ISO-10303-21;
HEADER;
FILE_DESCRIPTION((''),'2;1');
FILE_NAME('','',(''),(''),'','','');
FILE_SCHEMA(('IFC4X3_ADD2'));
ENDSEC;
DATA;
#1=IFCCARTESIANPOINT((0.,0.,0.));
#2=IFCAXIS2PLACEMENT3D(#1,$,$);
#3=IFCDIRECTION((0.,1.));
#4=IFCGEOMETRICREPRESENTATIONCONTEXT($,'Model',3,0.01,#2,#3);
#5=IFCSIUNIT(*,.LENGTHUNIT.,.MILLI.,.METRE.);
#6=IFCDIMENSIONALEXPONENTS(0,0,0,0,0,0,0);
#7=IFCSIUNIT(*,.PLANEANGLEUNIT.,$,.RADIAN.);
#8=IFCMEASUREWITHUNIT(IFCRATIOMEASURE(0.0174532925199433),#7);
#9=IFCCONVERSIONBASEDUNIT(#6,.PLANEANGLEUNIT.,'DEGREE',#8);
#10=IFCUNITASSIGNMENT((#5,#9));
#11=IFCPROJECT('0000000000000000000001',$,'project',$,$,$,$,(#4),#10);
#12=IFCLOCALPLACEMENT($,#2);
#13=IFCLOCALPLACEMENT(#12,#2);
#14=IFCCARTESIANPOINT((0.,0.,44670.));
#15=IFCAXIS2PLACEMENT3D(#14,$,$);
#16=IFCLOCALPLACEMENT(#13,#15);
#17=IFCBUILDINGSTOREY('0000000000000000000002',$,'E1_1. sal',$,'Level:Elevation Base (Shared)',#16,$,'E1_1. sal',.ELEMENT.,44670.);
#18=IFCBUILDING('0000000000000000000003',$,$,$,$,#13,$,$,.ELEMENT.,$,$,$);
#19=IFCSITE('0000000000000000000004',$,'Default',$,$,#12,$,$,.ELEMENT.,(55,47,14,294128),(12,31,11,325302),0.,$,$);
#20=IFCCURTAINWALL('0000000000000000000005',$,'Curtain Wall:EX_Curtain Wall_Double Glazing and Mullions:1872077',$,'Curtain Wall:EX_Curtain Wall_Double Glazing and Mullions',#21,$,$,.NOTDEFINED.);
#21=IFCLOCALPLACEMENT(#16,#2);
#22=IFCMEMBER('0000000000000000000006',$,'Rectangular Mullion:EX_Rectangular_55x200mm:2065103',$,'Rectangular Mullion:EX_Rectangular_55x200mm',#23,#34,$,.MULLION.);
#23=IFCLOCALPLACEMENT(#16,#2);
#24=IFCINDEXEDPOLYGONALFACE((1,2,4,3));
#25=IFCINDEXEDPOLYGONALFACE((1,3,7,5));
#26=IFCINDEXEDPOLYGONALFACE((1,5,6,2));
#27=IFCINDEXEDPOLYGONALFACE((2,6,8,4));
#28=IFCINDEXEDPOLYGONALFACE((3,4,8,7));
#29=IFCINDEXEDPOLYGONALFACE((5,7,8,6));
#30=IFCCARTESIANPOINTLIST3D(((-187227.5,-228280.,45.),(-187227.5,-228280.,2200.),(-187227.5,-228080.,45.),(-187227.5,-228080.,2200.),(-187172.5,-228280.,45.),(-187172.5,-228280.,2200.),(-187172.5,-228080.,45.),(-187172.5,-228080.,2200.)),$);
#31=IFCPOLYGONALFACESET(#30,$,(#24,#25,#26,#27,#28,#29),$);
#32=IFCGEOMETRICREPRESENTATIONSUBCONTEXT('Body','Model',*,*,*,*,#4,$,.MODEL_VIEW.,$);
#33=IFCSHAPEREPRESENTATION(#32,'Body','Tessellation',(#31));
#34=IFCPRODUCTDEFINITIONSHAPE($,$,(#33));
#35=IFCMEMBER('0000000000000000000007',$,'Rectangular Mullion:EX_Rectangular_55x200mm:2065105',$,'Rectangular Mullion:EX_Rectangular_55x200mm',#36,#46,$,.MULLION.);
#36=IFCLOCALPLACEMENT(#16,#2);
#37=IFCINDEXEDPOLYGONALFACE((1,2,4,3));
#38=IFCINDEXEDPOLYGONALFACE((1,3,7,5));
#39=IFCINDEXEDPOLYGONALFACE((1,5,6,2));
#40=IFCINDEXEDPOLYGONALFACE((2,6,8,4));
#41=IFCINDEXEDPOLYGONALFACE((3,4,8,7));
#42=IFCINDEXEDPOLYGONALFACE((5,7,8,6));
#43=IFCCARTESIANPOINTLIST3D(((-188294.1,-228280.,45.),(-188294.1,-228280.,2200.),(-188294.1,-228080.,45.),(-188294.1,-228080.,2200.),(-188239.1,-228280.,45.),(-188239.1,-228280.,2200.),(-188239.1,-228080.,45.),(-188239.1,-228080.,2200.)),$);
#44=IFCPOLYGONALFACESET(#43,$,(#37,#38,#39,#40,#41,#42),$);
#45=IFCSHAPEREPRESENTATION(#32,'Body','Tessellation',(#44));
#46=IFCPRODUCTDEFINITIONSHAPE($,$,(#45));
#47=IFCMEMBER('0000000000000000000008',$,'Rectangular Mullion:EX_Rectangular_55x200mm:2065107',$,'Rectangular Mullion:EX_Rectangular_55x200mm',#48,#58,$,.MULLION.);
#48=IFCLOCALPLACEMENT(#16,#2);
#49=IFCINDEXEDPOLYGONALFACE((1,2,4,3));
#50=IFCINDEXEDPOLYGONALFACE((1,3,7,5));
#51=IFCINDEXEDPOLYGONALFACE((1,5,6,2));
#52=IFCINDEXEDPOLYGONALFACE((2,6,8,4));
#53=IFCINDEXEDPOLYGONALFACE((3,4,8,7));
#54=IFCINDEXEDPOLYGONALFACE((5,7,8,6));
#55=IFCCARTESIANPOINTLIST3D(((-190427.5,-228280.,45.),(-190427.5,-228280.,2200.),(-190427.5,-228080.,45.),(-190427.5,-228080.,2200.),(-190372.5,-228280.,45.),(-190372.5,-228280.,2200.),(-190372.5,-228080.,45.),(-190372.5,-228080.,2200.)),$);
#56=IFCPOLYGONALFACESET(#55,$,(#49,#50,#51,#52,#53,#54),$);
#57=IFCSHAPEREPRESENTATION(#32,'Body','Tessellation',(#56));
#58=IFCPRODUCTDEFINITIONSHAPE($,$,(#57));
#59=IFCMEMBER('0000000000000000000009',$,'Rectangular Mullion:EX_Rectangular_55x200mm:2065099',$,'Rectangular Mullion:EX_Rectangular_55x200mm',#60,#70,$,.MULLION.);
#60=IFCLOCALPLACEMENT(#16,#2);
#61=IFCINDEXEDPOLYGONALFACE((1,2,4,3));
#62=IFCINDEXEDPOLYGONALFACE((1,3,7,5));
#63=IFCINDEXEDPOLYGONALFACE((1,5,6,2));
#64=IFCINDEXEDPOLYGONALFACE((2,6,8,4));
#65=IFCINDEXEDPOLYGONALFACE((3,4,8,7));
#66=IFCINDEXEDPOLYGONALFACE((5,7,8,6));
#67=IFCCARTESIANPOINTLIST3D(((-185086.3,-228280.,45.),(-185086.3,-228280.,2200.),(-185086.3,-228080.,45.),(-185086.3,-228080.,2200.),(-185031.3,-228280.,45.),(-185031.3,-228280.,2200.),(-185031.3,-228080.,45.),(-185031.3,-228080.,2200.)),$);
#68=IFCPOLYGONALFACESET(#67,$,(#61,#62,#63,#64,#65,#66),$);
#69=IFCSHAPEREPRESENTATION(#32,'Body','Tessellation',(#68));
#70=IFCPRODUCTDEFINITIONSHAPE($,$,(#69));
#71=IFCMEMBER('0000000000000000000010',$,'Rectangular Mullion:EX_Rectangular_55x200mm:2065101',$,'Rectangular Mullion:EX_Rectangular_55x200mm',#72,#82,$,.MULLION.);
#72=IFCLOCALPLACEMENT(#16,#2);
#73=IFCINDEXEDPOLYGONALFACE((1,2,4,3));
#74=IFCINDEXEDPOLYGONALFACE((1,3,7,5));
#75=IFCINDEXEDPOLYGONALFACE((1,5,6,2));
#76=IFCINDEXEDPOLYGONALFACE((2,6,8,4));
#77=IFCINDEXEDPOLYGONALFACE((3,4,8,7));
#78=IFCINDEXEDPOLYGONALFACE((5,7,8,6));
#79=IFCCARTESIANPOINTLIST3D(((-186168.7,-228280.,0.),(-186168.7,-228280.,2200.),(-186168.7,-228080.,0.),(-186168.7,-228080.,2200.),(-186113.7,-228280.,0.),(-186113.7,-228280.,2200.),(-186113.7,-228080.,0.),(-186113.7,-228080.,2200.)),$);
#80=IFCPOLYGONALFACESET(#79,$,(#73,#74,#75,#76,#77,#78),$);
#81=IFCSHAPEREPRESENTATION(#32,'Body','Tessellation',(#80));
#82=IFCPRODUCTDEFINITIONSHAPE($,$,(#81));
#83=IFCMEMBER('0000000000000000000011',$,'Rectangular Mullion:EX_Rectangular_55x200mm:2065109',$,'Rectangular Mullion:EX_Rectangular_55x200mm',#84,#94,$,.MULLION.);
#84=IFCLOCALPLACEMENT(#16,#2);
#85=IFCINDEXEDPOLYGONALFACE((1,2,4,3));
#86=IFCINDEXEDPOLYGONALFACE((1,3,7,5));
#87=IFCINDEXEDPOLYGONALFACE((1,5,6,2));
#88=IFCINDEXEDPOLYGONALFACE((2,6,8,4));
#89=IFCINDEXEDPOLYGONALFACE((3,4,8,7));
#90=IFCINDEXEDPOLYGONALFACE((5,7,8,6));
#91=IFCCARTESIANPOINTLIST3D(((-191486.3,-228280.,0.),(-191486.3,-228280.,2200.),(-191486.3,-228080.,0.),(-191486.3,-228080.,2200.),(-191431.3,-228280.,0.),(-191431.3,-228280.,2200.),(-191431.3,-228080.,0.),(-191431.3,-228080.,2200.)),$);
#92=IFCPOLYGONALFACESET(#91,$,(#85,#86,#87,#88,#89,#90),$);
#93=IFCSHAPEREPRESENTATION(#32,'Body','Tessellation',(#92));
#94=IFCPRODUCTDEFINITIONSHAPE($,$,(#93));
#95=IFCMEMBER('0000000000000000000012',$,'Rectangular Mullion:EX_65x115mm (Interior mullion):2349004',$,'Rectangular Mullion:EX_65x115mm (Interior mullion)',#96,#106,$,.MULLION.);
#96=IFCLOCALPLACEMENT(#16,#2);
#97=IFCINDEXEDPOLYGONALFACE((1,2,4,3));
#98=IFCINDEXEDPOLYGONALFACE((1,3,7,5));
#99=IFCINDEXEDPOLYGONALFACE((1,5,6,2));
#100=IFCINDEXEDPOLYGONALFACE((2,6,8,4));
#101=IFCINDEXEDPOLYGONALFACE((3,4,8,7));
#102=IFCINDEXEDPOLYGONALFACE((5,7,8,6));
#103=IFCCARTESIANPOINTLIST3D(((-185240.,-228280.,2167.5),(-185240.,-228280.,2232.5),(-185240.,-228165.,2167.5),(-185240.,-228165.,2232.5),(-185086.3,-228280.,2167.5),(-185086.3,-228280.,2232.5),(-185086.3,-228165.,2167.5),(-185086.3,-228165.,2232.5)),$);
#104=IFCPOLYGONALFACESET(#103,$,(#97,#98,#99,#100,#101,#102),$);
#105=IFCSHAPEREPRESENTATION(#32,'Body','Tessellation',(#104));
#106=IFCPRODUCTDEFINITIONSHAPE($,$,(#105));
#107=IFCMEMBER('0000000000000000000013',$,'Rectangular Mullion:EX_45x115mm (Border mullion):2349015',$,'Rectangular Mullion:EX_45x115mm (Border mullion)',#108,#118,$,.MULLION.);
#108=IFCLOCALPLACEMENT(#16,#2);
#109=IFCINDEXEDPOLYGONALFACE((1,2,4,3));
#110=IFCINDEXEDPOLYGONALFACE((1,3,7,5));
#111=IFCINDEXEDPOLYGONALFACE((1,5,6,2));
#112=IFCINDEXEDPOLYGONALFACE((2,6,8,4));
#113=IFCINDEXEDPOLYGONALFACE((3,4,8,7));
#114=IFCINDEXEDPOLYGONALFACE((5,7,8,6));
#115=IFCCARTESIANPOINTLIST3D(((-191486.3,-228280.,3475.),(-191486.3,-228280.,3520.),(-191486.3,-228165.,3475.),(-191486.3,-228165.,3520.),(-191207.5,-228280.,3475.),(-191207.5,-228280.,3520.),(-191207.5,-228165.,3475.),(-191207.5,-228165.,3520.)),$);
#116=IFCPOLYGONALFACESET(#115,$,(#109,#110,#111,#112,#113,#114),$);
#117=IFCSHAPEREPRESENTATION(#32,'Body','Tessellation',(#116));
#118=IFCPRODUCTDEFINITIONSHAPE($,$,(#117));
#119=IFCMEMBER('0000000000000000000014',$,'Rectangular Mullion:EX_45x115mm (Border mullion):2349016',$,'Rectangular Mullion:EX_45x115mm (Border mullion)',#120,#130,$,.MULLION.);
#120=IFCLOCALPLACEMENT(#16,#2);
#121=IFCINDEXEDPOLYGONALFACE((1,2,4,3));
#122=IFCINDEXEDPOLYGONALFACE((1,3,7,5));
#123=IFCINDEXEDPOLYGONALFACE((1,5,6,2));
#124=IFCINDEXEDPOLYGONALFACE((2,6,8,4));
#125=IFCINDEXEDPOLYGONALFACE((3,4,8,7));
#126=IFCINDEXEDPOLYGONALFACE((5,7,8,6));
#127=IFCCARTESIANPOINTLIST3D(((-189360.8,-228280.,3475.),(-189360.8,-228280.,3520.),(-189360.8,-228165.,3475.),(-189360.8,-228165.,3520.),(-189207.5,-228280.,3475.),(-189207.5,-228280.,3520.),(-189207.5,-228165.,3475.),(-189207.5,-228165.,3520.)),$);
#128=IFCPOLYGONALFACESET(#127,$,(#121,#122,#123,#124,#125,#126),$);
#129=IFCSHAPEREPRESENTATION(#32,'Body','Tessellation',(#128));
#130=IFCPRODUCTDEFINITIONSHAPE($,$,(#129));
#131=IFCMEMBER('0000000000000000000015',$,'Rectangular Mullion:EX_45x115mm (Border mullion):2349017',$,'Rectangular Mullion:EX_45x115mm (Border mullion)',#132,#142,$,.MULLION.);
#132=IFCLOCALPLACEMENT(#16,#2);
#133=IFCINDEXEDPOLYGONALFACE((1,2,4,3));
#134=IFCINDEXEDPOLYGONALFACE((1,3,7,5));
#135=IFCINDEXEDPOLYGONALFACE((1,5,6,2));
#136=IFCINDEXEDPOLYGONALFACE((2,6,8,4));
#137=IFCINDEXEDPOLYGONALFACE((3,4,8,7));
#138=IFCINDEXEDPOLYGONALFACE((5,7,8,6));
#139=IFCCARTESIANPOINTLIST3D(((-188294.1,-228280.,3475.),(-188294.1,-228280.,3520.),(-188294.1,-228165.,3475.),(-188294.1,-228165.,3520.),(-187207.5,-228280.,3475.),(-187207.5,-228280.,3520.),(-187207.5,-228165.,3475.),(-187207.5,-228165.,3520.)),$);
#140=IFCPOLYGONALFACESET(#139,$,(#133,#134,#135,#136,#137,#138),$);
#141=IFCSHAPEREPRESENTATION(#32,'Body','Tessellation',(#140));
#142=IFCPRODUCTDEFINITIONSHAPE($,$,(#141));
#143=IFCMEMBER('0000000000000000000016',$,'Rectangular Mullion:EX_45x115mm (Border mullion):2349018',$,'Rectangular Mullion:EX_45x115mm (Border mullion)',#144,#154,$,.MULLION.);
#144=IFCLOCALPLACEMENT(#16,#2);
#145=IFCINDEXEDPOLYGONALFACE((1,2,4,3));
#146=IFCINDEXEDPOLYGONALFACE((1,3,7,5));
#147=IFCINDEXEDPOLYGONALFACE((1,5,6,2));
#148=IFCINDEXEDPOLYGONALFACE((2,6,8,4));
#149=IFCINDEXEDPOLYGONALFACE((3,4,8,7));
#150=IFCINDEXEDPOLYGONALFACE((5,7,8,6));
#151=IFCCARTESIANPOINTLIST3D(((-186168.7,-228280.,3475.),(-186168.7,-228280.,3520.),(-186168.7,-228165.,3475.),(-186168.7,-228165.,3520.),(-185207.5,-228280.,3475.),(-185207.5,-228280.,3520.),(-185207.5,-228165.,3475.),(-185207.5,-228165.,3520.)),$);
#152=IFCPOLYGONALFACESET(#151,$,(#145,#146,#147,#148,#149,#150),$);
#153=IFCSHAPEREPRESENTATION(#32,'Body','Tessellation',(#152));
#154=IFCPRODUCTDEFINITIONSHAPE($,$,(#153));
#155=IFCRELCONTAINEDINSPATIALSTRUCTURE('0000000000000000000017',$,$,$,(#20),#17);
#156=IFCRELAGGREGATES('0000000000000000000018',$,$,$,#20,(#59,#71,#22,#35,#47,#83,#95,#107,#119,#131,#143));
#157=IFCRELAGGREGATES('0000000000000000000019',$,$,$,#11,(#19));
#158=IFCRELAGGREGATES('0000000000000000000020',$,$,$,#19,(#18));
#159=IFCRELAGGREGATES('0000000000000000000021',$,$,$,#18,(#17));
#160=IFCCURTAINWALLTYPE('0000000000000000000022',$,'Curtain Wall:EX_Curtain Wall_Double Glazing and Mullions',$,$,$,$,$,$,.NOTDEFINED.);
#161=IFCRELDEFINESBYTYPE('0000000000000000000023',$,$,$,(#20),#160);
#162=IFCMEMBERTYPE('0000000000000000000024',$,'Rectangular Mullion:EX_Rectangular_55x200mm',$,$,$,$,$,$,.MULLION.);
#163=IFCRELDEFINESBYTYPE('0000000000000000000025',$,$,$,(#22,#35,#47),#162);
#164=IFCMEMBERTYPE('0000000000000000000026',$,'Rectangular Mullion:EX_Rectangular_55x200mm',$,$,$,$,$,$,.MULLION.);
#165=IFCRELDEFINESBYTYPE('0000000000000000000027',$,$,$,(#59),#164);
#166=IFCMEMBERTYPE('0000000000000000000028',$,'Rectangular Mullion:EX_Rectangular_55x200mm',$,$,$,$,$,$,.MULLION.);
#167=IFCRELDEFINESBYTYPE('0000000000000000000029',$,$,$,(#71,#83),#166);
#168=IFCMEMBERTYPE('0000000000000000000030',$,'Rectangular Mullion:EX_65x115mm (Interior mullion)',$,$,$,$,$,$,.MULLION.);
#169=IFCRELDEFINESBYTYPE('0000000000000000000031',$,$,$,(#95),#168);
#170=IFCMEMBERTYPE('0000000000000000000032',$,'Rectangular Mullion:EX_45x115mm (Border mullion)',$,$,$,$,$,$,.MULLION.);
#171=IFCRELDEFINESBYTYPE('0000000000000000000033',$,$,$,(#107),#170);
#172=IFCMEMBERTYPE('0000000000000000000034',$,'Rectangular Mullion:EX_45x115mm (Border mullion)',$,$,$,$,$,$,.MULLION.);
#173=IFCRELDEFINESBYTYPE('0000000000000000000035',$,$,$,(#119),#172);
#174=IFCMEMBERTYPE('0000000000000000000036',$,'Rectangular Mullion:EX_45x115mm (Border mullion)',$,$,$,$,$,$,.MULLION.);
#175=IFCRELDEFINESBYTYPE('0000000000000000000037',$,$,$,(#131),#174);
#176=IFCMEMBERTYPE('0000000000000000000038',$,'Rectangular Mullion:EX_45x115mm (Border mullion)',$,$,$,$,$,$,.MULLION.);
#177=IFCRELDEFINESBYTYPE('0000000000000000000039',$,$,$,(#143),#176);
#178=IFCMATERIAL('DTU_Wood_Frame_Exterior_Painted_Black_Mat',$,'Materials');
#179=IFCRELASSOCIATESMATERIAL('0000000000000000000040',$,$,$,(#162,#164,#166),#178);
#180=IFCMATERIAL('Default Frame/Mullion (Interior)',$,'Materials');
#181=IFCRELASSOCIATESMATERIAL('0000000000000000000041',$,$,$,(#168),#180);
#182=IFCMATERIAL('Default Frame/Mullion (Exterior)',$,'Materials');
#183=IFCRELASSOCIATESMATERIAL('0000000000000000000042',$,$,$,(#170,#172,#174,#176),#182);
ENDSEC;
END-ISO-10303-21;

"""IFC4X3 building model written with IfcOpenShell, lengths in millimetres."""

from ifc_helpers import new_model, entity, si_unit, converted_unit, direction, frame, origin, origin_2d_with_axis, place, context, subcontext, project, spatial, rectangle, extrude, source, transform, mapped, material, material_profile, profile_set, type_object, type_shapes, element, aggregate, save


model = new_model("IFC4X3")

# Units and contexts
model_context = context("Model", 3, precision=0.01, world=origin(), true_north=direction((0.0, 1.0)))
body_context = subcontext(model_context, "Body", "Model", "MODEL_VIEW")
ifc_project = project(units=[si_unit("LENGTHUNIT", "METRE", prefix="MILLI"), converted_unit("PLANEANGLEUNIT", "DEGREE", entity("IfcRatioMeasure", 0.0174532925199433), si_unit("PLANEANGLEUNIT", "RADIAN"), dimensions=[0, 0, 0, 0, 0, 0, 0])], contexts=[model_context])

# Site, building, storey
site_placement = place(None, origin())
site = spatial("IfcSite", under=ifc_project, at=site_placement, Name="Default", CompositionType="ELEMENT", RefLatitude=(55, 47, 14, 294128), RefLongitude=(12, 31, 11, 325302), RefElevation=0.0)
building_placement = place(site_placement, origin())
building = spatial("IfcBuilding", under=site, at=building_placement, CompositionType="ELEMENT")
storey_placement = place(building_placement, frame((0.0, 0.0, 44670.0)))
storey = spatial("IfcBuildingStorey", under=building, at=storey_placement, Name="E1_1. sal", ObjectType="Level:Elevation Base (Shared)", LongName="E1_1. sal", CompositionType="ELEMENT", Elevation=44670.0)

# Curtain wall, members
curtain_wall_type = type_object("IfcCurtainWallType", Name="Curtain Wall:EX_Curtain Wall_Double Glazing and Mullions", PredefinedType="NOTDEFINED")
curtain_wall_placement = place(storey_placement, frame((0.0, 0.0, -44670.0)))
curtain_wall = element("IfcCurtainWall", 1, at=curtain_wall_placement, inside=storey, type_object=curtain_wall_type, Name="Curtain Wall:EX_Curtain Wall_Double Glazing and Mullions:1872077", ObjectType="Curtain Wall:EX_Curtain Wall_Double Glazing and Mullions", PredefinedType="NOTDEFINED")
ifc_material_1 = material(Name="DTU_Wood_Frame_Exterior_Painted_Black_Mat", Category="Materials")
ifc_material_profile_1 = material_profile(ifc_material_1, rectangle(XDim=200.0, YDim=55.0, at=origin_2d_with_axis()), Name="EX_Rectangular_55x200mm")
ifc_profile_set_1 = profile_set([ifc_material_profile_1], Name="EX_Rectangular_55x200mm")
member_type_1 = type_object("IfcMemberType", Name="Rectangular Mullion:EX_Rectangular_55x200mm", PredefinedType="MULLION", material=ifc_profile_set_1)
shared_shape_1 = source(origin(), body_context, "Body", "SweptSolid", [
    extrude(rectangle(XDim=200.0, YDim=55.0, at=origin_2d_with_axis()), frame((0.0, -100.0, -2155.0), z_axis=(0.0, 0.0, 1.0), x_axis=(0.0, -1.0, 0.0)), (0.0, 0.0, 1.0), 2155.0),
])
type_shapes(member_type_1, [shared_shape_1])
member_1_placement = place(curtain_wall_placement, frame((-187200.0, -228280.0, 44715.0), z_axis=(0.0, 0.0, -1.0), x_axis=(1.0, 0.0, 0.0)))
member_1 = element("IfcMember", 2, at=member_1_placement, type_object=member_type_1, Name="Rectangular Mullion:EX_Rectangular_55x200mm:2065103", ObjectType="Rectangular Mullion:EX_Rectangular_55x200mm", PredefinedType="MULLION", context=body_context, shape_type="MappedRepresentation", body=[
    mapped(shared_shape_1, transform((0.0, 0.0, 0.0), scale=1.0)),
])
member_2_placement = place(curtain_wall_placement, frame((-188266.6, -228280.0, 44715.0), z_axis=(0.0, 0.0, -1.0), x_axis=(1.0, 0.0, 0.0)))
member_2 = element("IfcMember", 3, at=member_2_placement, type_object=member_type_1, Name="Rectangular Mullion:EX_Rectangular_55x200mm:2065105", ObjectType="Rectangular Mullion:EX_Rectangular_55x200mm", PredefinedType="MULLION", context=body_context, shape_type="MappedRepresentation", body=[
    mapped(shared_shape_1, transform((0.0, 0.0, 0.0), scale=1.0)),
])
member_3_placement = place(curtain_wall_placement, frame((-190400.0, -228280.0, 44715.0), z_axis=(0.0, 0.0, -1.0), x_axis=(1.0, 0.0, 0.0)))
member_3 = element("IfcMember", 4, at=member_3_placement, type_object=member_type_1, Name="Rectangular Mullion:EX_Rectangular_55x200mm:2065107", ObjectType="Rectangular Mullion:EX_Rectangular_55x200mm", PredefinedType="MULLION", context=body_context, shape_type="MappedRepresentation", body=[
    mapped(shared_shape_1, transform((0.0, 0.0, 0.0), scale=1.0)),
])
member_type_2 = type_object("IfcMemberType", Name="Rectangular Mullion:EX_Rectangular_55x200mm", PredefinedType="MULLION", material=ifc_profile_set_1)
shared_shape_2 = source(origin(), body_context, "Body", "SweptSolid", [
    extrude(rectangle(XDim=200.0, YDim=55.0, at=origin_2d_with_axis()), frame((0.0, -100.0, -2155.0), z_axis=(0.0, 0.0, 1.0), x_axis=(0.0, -1.0, 0.0)), (0.0, 0.0, 1.0), 2155.0),
])
type_shapes(member_type_2, [shared_shape_2])
member_4_placement = place(curtain_wall_placement, frame((-185058.8, -228280.0, 44715.0), z_axis=(0.0, 0.0, -1.0), x_axis=(1.0, 0.0, 0.0)))
member_4 = element("IfcMember", 5, at=member_4_placement, type_object=member_type_2, Name="Rectangular Mullion:EX_Rectangular_55x200mm:2065099", ObjectType="Rectangular Mullion:EX_Rectangular_55x200mm", PredefinedType="MULLION", context=body_context, shape_type="MappedRepresentation", body=[
    mapped(shared_shape_2, transform((0.0, 0.0, 0.0), scale=1.0)),
])
member_type_3 = type_object("IfcMemberType", Name="Rectangular Mullion:EX_Rectangular_55x200mm", PredefinedType="MULLION", material=ifc_profile_set_1)
shared_shape_3 = source(origin(), body_context, "Body", "SweptSolid", [
    extrude(rectangle(XDim=200.0, YDim=55.0, at=origin_2d_with_axis()), frame((0.0, -100.0, -2200.0), z_axis=(0.0, 0.0, 1.0), x_axis=(0.0, -1.0, 0.0)), (0.0, 0.0, 1.0), 2200.0),
])
type_shapes(member_type_3, [shared_shape_3])
member_5_placement = place(curtain_wall_placement, frame((-186141.2, -228280.0, 44670.0), z_axis=(0.0, 0.0, -1.0), x_axis=(1.0, 0.0, 0.0)))
member_5 = element("IfcMember", 6, at=member_5_placement, type_object=member_type_3, Name="Rectangular Mullion:EX_Rectangular_55x200mm:2065101", ObjectType="Rectangular Mullion:EX_Rectangular_55x200mm", PredefinedType="MULLION", context=body_context, shape_type="MappedRepresentation", body=[
    mapped(shared_shape_3, transform((0.0, 0.0, 0.0), scale=1.0)),
])
member_6_placement = place(curtain_wall_placement, frame((-191458.8, -228280.0, 44670.0), z_axis=(0.0, 0.0, -1.0), x_axis=(1.0, 0.0, 0.0)))
member_6 = element("IfcMember", 7, at=member_6_placement, type_object=member_type_3, Name="Rectangular Mullion:EX_Rectangular_55x200mm:2065109", ObjectType="Rectangular Mullion:EX_Rectangular_55x200mm", PredefinedType="MULLION", context=body_context, shape_type="MappedRepresentation", body=[
    mapped(shared_shape_3, transform((0.0, 0.0, 0.0), scale=1.0)),
])
ifc_material_2 = material(Name="Default Frame/Mullion (Interior)", Category="Materials")
ifc_material_profile_2 = material_profile(ifc_material_2, rectangle(XDim=115.0, YDim=65.0, at=origin_2d_with_axis()), Name="EX_65x115mm (Interior mullion)")
ifc_profile_set_2 = profile_set([ifc_material_profile_2], Name="EX_65x115mm (Interior mullion)")
member_type_4 = type_object("IfcMemberType", Name="Rectangular Mullion:EX_65x115mm (Interior mullion)", PredefinedType="MULLION", material=ifc_profile_set_2)
shared_shape_4 = source(origin(), body_context, "Body", "SweptSolid", [
    extrude(rectangle(XDim=115.0, YDim=65.0, at=origin_2d_with_axis()), frame((0.0, -57.5, -153.7), z_axis=(0.0, 0.0, 1.0), x_axis=(0.0, -1.0, 0.0)), (0.0, 0.0, 1.0), 153.7),
])
type_shapes(member_type_4, [shared_shape_4])
member_7_placement = place(curtain_wall_placement, frame((-185086.3, -228280.0, 46870.0), z_axis=(1.0, 0.0, 0.0), x_axis=(0.0, 0.0, 1.0)))
member_7 = element("IfcMember", 8, at=member_7_placement, type_object=member_type_4, Name="Rectangular Mullion:EX_65x115mm (Interior mullion):2349004", ObjectType="Rectangular Mullion:EX_65x115mm (Interior mullion)", PredefinedType="MULLION", context=body_context, shape_type="MappedRepresentation", body=[
    mapped(shared_shape_4, transform((0.0, 0.0, 0.0), scale=1.0)),
])
ifc_material_3 = material(Name="Default Frame/Mullion (Exterior)", Category="Materials")
ifc_material_profile_3 = material_profile(ifc_material_3, rectangle(XDim=115.0, YDim=45.0, at=origin_2d_with_axis()), Name="EX_45x115mm (Border mullion)")
ifc_profile_set_3 = profile_set([ifc_material_profile_3], Name="EX_45x115mm (Border mullion)")
member_type_5 = type_object("IfcMemberType", Name="Rectangular Mullion:EX_45x115mm (Border mullion)", PredefinedType="MULLION", material=ifc_profile_set_3)
shared_shape_5 = source(origin(), body_context, "Body", "SweptSolid", [
    extrude(rectangle(XDim=115.0, YDim=45.0, at=origin_2d_with_axis()), frame((-22.5, -57.5, -278.8), z_axis=(0.0, 0.0, 1.0), x_axis=(0.0, -1.0, 0.0)), (0.0, 0.0, 1.0), 278.8),
])
type_shapes(member_type_5, [shared_shape_5])
member_8_placement = place(curtain_wall_placement, frame((-191207.5, -228280.0, 48190.0), z_axis=(1.0, 0.0, 0.0), x_axis=(0.0, 0.0, 1.0)))
member_8 = element("IfcMember", 9, at=member_8_placement, type_object=member_type_5, Name="Rectangular Mullion:EX_45x115mm (Border mullion):2349015", ObjectType="Rectangular Mullion:EX_45x115mm (Border mullion)", PredefinedType="MULLION", context=body_context, shape_type="MappedRepresentation", body=[
    mapped(shared_shape_5, transform((0.0, 0.0, 0.0), scale=1.0)),
])
member_type_6 = type_object("IfcMemberType", Name="Rectangular Mullion:EX_45x115mm (Border mullion)", PredefinedType="MULLION", material=ifc_profile_set_3)
shared_shape_6 = source(origin(), body_context, "Body", "SweptSolid", [
    extrude(rectangle(XDim=115.0, YDim=45.0, at=origin_2d_with_axis()), frame((-22.5, -57.5, -153.3), z_axis=(0.0, 0.0, 1.0), x_axis=(0.0, -1.0, 0.0)), (0.0, 0.0, 1.0), 153.3),
])
type_shapes(member_type_6, [shared_shape_6])
member_9_placement = place(curtain_wall_placement, frame((-189207.5, -228280.0, 48190.0), z_axis=(1.0, 0.0, 0.0), x_axis=(0.0, 0.0, 1.0)))
member_9 = element("IfcMember", 10, at=member_9_placement, type_object=member_type_6, Name="Rectangular Mullion:EX_45x115mm (Border mullion):2349016", ObjectType="Rectangular Mullion:EX_45x115mm (Border mullion)", PredefinedType="MULLION", context=body_context, shape_type="MappedRepresentation", body=[
    mapped(shared_shape_6, transform((0.0, 0.0, 0.0), scale=1.0)),
])
member_type_7 = type_object("IfcMemberType", Name="Rectangular Mullion:EX_45x115mm (Border mullion)", PredefinedType="MULLION", material=ifc_profile_set_3)
shared_shape_7 = source(origin(), body_context, "Body", "SweptSolid", [
    extrude(rectangle(XDim=115.0, YDim=45.0, at=origin_2d_with_axis()), frame((-22.5, -57.5, -1086.6), z_axis=(0.0, 0.0, 1.0), x_axis=(0.0, -1.0, 0.0)), (0.0, 0.0, 1.0), 1086.6),
])
type_shapes(member_type_7, [shared_shape_7])
member_10_placement = place(curtain_wall_placement, frame((-187207.5, -228280.0, 48190.0), z_axis=(1.0, 0.0, 0.0), x_axis=(0.0, 0.0, 1.0)))
member_10 = element("IfcMember", 11, at=member_10_placement, type_object=member_type_7, Name="Rectangular Mullion:EX_45x115mm (Border mullion):2349017", ObjectType="Rectangular Mullion:EX_45x115mm (Border mullion)", PredefinedType="MULLION", context=body_context, shape_type="MappedRepresentation", body=[
    mapped(shared_shape_7, transform((0.0, 0.0, 0.0), scale=1.0)),
])
member_type_8 = type_object("IfcMemberType", Name="Rectangular Mullion:EX_45x115mm (Border mullion)", PredefinedType="MULLION", material=ifc_profile_set_3)
shared_shape_8 = source(origin(), body_context, "Body", "SweptSolid", [
    extrude(rectangle(XDim=115.0, YDim=45.0, at=origin_2d_with_axis()), frame((-22.5, -57.5, -961.2), z_axis=(0.0, 0.0, 1.0), x_axis=(0.0, -1.0, 0.0)), (0.0, 0.0, 1.0), 961.2),
])
type_shapes(member_type_8, [shared_shape_8])
member_11_placement = place(curtain_wall_placement, frame((-185207.5, -228280.0, 48190.0), z_axis=(1.0, 0.0, 0.0), x_axis=(0.0, 0.0, 1.0)))
member_11 = element("IfcMember", 12, at=member_11_placement, type_object=member_type_8, Name="Rectangular Mullion:EX_45x115mm (Border mullion):2349018", ObjectType="Rectangular Mullion:EX_45x115mm (Border mullion)", PredefinedType="MULLION", context=body_context, shape_type="MappedRepresentation", body=[
    mapped(shared_shape_8, transform((0.0, 0.0, 0.0), scale=1.0)),
])
aggregate(curtain_wall, [member_4, member_5, member_1, member_2, member_3, member_6, member_7, member_8, member_9, member_10, member_11])

save(model, "model.ifc")
